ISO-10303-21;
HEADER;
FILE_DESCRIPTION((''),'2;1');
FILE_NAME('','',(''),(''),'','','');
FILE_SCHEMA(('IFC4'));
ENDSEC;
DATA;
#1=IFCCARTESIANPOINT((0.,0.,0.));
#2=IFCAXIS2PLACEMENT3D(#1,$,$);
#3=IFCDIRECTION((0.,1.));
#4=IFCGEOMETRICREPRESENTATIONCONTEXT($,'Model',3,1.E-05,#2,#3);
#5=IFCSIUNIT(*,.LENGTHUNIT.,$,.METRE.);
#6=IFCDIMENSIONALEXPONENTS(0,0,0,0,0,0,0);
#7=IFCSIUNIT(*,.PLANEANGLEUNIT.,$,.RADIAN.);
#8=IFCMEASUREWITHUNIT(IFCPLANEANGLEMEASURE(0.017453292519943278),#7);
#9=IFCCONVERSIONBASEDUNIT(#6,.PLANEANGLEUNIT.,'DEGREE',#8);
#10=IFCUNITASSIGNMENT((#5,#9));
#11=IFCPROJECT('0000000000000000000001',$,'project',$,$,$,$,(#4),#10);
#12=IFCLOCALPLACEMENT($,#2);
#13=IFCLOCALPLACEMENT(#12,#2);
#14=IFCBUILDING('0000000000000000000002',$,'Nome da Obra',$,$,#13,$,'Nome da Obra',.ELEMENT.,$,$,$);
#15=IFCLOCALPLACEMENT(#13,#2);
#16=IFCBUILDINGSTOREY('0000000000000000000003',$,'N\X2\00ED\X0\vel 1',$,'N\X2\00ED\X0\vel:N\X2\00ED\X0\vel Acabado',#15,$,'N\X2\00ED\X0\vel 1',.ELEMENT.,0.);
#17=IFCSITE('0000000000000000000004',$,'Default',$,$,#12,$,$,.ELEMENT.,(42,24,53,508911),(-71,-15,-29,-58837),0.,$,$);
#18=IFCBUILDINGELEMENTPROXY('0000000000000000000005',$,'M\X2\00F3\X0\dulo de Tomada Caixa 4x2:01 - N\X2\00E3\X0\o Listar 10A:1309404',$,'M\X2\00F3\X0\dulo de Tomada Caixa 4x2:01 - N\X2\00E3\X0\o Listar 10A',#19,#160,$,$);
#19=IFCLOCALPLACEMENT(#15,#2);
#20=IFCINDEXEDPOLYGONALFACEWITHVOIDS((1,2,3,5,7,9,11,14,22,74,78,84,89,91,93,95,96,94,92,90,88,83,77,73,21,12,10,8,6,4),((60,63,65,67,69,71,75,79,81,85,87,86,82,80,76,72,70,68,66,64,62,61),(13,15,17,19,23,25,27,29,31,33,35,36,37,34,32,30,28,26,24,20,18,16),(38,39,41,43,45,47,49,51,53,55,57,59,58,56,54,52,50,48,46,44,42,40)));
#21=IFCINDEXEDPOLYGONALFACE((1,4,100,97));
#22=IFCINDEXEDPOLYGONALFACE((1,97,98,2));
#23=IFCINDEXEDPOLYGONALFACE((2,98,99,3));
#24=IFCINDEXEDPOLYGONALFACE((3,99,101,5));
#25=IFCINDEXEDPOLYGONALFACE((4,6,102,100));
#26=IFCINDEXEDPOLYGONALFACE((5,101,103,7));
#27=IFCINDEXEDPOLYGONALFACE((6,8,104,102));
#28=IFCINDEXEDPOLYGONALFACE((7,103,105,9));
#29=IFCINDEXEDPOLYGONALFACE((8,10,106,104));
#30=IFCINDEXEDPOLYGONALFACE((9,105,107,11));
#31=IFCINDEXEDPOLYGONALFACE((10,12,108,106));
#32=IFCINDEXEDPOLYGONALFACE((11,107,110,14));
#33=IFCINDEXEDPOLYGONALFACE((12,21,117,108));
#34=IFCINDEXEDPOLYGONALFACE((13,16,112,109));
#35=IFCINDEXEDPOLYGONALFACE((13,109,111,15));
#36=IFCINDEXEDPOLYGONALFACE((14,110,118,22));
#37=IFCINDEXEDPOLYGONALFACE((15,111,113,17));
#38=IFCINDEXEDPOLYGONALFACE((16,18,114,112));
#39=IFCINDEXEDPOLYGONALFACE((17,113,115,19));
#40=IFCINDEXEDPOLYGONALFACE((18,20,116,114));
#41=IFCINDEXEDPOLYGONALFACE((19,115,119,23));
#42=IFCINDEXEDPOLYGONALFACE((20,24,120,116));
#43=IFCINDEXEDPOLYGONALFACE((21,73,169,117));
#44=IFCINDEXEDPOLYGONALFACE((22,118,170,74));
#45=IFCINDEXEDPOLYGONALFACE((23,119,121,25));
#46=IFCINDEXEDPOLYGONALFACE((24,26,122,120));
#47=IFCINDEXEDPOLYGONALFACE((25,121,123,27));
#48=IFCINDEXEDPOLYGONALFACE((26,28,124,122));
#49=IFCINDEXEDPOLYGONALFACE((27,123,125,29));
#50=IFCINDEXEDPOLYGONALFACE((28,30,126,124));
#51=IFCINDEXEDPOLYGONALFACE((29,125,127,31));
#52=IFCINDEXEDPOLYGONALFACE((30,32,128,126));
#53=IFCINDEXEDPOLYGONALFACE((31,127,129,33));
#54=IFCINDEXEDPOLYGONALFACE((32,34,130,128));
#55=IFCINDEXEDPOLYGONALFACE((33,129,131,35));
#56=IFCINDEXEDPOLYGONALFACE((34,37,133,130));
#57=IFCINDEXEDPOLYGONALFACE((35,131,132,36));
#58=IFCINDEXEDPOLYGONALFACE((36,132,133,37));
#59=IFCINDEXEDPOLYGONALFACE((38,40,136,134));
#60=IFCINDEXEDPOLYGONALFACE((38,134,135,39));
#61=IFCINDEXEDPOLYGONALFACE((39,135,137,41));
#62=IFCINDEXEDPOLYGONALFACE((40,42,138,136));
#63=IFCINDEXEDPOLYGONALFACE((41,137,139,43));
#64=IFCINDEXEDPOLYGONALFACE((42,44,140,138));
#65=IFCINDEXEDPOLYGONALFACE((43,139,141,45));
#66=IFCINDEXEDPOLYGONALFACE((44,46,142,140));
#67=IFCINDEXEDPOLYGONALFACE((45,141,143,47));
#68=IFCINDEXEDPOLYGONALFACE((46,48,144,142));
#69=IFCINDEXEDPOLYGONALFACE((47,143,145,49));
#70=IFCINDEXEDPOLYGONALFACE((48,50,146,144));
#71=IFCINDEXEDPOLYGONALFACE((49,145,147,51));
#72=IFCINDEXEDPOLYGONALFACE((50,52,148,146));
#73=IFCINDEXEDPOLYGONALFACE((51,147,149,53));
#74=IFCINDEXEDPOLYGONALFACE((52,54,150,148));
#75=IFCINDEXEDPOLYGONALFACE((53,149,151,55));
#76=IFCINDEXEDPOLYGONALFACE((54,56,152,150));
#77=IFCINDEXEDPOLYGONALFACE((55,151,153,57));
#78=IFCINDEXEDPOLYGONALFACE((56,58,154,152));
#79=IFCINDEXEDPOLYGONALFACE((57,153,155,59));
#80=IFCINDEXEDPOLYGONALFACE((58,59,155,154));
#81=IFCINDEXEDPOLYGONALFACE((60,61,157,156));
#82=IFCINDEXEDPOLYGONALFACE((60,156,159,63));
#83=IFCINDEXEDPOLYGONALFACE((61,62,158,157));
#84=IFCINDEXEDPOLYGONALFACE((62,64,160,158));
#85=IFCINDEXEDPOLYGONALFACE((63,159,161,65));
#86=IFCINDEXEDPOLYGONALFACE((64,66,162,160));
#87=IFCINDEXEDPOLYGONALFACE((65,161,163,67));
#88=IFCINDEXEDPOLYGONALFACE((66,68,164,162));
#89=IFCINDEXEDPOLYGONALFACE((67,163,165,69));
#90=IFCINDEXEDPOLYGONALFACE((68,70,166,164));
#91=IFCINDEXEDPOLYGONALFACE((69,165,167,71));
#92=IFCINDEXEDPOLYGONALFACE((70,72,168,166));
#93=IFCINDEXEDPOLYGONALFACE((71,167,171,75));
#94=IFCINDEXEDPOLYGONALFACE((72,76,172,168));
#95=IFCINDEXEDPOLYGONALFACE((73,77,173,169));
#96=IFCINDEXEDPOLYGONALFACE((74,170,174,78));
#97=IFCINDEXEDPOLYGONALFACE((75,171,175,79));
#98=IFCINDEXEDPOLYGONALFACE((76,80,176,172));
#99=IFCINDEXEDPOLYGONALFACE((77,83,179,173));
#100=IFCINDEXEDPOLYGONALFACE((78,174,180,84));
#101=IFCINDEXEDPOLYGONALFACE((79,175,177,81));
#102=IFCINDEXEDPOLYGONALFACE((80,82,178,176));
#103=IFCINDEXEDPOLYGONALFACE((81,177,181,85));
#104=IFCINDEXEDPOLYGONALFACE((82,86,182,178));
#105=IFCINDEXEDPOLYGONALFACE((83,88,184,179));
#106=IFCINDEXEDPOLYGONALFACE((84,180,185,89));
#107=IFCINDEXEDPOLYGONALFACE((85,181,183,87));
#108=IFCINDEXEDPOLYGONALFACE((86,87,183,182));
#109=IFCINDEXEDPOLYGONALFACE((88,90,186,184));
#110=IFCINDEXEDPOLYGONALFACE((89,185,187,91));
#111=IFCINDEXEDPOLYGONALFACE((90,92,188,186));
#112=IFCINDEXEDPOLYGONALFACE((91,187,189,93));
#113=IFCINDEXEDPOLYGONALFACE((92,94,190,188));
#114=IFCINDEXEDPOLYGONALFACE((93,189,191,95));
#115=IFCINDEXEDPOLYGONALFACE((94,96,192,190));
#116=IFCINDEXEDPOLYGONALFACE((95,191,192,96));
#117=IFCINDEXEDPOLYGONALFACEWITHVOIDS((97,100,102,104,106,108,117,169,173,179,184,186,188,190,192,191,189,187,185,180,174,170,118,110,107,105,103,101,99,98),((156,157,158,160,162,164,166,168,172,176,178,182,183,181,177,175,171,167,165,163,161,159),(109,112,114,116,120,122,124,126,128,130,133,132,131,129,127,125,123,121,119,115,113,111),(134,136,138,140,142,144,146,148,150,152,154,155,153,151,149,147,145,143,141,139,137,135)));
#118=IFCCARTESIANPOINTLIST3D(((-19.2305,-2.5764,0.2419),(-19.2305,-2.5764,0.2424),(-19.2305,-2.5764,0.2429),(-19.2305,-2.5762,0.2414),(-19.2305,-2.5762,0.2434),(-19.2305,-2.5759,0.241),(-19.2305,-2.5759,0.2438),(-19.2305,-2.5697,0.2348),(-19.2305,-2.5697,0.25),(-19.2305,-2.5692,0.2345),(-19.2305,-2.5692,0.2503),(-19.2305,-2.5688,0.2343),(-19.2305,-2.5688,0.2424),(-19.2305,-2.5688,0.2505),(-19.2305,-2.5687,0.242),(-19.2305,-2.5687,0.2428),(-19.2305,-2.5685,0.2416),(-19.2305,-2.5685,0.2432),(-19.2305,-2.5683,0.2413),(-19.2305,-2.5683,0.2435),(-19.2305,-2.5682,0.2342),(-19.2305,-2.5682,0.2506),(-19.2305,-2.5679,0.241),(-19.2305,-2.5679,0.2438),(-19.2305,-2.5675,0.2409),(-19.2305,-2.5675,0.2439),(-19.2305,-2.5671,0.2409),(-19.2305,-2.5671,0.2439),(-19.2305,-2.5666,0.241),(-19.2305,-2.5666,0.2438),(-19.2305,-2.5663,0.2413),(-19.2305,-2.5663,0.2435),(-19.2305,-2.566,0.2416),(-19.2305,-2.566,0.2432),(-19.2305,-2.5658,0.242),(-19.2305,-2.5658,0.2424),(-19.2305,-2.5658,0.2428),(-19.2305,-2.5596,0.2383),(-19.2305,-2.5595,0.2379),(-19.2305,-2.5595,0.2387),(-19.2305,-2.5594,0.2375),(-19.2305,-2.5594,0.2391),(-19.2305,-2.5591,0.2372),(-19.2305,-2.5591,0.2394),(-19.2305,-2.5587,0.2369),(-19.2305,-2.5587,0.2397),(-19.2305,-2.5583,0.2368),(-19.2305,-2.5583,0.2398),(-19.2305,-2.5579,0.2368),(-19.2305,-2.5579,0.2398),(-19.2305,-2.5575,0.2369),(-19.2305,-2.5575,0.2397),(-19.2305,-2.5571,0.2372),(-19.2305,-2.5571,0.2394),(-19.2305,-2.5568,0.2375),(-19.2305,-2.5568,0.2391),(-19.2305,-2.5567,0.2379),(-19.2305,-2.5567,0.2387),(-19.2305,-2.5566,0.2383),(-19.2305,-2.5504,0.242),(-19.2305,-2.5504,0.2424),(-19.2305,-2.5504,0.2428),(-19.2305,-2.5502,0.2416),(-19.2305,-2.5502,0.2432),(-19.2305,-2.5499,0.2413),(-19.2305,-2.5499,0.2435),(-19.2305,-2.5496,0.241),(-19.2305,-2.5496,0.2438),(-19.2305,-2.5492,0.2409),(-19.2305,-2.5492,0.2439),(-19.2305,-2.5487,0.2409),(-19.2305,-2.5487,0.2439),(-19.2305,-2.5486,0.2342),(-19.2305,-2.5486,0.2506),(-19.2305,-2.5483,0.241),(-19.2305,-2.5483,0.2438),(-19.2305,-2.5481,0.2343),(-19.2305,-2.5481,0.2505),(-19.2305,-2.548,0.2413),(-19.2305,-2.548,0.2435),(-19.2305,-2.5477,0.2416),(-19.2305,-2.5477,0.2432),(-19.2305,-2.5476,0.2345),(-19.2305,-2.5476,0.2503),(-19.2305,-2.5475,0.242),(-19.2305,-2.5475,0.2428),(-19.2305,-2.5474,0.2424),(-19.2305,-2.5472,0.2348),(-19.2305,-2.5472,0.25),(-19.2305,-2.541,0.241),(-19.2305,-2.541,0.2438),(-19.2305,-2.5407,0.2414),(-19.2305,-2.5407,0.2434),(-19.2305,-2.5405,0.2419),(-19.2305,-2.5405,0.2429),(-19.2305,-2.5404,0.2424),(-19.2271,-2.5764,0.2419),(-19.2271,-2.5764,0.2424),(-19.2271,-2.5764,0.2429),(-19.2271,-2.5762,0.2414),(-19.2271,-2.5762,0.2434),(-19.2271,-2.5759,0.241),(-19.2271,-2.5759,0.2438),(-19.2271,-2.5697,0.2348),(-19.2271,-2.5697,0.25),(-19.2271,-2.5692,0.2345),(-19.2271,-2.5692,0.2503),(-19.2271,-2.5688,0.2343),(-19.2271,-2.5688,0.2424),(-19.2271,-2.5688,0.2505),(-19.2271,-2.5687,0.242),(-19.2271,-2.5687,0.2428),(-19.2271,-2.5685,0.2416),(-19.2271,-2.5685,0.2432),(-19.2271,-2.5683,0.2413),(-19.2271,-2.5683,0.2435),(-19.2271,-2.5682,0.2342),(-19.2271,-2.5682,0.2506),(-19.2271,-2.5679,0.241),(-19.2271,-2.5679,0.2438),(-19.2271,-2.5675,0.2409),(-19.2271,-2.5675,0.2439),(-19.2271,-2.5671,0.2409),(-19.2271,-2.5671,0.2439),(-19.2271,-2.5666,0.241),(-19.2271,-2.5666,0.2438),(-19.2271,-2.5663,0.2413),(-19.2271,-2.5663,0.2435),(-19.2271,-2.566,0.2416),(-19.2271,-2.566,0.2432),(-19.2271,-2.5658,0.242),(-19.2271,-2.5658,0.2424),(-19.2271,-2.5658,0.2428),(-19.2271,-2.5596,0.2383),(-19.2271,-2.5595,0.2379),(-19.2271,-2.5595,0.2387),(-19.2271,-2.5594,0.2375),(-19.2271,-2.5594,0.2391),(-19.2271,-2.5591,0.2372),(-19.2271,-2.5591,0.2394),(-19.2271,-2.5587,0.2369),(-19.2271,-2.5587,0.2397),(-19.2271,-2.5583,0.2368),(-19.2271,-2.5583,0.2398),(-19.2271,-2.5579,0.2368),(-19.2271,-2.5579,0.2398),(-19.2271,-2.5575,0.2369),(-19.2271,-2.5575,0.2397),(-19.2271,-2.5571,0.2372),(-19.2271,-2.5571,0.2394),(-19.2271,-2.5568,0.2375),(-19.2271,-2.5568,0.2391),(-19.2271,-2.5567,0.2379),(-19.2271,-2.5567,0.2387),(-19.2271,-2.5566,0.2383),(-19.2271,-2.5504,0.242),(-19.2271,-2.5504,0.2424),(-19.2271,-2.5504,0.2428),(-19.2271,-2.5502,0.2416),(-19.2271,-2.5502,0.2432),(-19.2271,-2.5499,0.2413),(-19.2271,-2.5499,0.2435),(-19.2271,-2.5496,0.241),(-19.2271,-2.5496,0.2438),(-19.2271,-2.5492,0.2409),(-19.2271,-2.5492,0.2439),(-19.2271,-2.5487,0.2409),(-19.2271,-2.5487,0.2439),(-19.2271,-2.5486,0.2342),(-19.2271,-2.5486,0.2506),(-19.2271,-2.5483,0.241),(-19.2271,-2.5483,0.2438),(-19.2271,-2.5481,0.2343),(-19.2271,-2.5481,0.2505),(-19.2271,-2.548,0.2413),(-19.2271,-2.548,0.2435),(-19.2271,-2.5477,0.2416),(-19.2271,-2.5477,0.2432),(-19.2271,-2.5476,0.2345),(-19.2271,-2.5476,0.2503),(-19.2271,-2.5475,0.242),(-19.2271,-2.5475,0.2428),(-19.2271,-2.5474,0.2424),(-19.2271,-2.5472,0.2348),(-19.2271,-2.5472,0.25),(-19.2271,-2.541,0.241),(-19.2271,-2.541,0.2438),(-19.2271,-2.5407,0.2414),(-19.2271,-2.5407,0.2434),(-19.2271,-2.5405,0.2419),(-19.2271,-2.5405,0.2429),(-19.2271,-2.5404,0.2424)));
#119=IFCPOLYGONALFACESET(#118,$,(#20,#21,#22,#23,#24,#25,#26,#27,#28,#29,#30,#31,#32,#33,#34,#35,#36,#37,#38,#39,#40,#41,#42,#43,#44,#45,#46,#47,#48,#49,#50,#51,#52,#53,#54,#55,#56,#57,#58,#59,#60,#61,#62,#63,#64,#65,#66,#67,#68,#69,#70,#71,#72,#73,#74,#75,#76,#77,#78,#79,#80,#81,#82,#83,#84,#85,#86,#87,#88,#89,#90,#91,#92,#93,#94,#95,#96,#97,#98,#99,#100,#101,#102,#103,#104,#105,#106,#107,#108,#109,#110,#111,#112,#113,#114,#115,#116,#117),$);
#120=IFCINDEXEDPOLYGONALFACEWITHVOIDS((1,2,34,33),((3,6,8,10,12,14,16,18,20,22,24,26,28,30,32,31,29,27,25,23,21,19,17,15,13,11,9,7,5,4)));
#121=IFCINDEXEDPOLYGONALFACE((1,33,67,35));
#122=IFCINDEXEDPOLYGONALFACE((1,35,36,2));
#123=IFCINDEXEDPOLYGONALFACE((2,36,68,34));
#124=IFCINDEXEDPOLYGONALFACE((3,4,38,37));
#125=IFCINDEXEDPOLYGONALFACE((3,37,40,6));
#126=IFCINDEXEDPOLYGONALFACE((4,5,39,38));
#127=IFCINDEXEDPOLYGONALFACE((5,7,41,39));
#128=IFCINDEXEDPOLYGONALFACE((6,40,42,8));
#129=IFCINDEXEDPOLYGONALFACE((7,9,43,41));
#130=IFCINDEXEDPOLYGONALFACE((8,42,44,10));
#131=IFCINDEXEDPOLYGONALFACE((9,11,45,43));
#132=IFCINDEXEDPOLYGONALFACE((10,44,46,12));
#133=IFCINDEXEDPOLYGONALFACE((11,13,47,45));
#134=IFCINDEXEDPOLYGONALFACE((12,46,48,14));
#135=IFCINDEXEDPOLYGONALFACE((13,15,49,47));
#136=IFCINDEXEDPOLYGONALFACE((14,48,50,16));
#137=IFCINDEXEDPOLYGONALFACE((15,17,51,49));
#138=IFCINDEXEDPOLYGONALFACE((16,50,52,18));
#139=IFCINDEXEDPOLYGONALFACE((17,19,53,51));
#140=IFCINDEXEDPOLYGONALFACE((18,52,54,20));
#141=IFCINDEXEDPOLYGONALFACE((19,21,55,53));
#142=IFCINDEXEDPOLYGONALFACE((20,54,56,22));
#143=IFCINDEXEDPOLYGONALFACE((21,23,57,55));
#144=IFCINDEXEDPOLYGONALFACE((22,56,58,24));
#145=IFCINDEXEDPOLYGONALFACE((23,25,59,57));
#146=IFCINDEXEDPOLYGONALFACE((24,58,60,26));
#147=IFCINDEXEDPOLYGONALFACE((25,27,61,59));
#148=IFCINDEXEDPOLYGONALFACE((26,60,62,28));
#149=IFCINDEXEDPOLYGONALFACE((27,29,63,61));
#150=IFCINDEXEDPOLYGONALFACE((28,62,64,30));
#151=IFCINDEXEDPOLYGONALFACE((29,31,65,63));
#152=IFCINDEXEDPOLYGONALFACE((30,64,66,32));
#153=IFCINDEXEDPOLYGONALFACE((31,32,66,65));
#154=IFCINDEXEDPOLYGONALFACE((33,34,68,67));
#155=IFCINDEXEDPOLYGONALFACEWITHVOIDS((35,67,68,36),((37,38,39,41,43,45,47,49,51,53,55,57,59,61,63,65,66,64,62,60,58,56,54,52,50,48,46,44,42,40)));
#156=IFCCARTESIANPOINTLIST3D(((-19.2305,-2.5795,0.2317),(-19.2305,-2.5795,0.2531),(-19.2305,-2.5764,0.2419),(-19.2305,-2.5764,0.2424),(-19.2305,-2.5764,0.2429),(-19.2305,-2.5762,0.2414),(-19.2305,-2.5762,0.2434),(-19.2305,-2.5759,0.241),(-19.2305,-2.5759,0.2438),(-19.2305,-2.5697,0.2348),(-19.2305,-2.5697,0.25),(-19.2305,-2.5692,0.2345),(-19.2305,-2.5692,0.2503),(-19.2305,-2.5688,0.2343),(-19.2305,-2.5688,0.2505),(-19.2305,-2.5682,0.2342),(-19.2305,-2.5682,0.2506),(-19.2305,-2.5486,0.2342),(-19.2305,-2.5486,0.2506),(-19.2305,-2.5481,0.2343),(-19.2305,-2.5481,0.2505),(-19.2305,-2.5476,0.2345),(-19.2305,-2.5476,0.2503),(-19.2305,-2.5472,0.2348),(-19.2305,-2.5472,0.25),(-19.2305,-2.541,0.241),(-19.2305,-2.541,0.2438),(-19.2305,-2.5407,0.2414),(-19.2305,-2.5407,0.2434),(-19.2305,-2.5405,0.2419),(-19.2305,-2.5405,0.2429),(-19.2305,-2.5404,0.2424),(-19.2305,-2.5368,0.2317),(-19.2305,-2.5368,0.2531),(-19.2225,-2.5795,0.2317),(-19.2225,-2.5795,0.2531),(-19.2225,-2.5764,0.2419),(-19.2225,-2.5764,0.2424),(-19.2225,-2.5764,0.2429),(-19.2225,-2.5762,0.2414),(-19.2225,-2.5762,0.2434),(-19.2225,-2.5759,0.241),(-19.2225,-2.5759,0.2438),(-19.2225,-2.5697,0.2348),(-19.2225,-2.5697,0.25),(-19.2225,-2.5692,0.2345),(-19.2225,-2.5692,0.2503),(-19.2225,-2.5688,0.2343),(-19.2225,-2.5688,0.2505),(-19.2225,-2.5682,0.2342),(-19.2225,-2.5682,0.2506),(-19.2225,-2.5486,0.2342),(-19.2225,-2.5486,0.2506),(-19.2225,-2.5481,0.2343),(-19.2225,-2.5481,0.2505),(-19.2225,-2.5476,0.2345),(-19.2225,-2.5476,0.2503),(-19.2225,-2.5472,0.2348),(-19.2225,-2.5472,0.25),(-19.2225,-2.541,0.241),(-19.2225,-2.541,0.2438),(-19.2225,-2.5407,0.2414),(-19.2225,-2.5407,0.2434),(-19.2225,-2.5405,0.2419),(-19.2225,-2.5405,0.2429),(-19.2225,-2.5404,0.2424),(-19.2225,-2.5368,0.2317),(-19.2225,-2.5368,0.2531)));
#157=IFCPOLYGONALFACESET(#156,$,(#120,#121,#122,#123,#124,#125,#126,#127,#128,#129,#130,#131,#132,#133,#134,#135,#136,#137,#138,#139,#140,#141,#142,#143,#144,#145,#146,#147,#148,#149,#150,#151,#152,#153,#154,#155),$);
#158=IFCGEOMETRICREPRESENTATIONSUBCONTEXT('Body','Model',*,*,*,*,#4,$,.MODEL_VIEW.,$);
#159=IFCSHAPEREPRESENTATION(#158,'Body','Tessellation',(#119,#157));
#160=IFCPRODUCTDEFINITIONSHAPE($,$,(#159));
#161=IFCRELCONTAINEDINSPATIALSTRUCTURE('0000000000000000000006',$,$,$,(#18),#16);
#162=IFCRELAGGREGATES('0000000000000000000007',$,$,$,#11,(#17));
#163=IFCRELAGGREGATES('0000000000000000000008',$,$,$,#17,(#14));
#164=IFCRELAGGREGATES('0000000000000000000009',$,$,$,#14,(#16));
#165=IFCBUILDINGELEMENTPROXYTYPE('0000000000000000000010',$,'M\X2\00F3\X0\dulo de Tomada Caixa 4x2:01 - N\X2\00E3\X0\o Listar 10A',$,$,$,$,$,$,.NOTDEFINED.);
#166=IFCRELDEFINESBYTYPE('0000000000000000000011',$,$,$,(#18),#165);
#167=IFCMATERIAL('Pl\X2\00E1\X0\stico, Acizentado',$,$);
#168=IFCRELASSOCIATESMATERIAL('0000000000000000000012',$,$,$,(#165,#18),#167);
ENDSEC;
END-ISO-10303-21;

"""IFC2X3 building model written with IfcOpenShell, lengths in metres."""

from ifc_helpers import new_model, entity, si_unit, converted_unit, direction, frame, frame_2d, origin, place, context, subcontext, project, spatial, polyline, circle_curve, parameter, trimmed, segment, composite_curve, outline, extrude, source, transform, mapped, material, type_object, type_shapes, element, save


model = new_model("IFC2X3")

# Units and contexts
model_context = context("Model", 3, precision=1e-05, world=origin(), true_north=direction((0.0, 1.0)))
body_context = subcontext(model_context, "Body", "Model", "MODEL_VIEW")
ifc_project = project(units=[si_unit("LENGTHUNIT", "METRE"), converted_unit("PLANEANGLEUNIT", "DEGREE", entity("IfcPlaneAngleMeasure", 0.017453292519943278), si_unit("PLANEANGLEUNIT", "RADIAN"), dimensions=[0, 0, 0, 0, 0, 0, 0])], contexts=[model_context])

# Site, building, storey
site_placement = place(None, origin())
site = spatial("IfcSite", under=ifc_project, at=site_placement, Name="Default", CompositionType="ELEMENT", RefLatitude=(42, 24, 53, 508911), RefLongitude=(-71, -15, -29, -58837), RefElevation=0.0)
building_placement = place(site_placement, origin())
building = spatial("IfcBuilding", under=site, at=building_placement, Name="Nome da Obra", LongName="Nome da Obra", CompositionType="ELEMENT")
storey_placement = place(building_placement, origin())
storey = spatial("IfcBuildingStorey", under=building, at=storey_placement, Name="Nível 1", ObjectType="Nível:Nível Acabado", LongName="Nível 1", CompositionType="ELEMENT", Elevation=0.0)

# Building element proxy
ifc_material_1 = material(Name="Plástico, Acizentado")
building_element_proxy_type_1 = type_object("IfcBuildingElementProxyType", Name="Módulo de Tomada Caixa 4x2:01 - Não Listar 10A", PredefinedType="NOTDEFINED", material=ifc_material_1)
shared_shape_1 = source(origin(), body_context, "Body", "SweptSolid", [
    extrude(outline(composite_curve([segment(polyline([(-0.0098, -0.0082), (0.0098, -0.0082)]), True, "CONTINUOUS"), segment(trimmed(circle_curve(frame_2d((0.0098, -0.0062), x_axis=(1.0, 0.0)), 0.002), [parameter(270.0)], [parameter(315.0)], True, "PARAMETER"), True, "CONTINUOUS"), segment(polyline([(0.0112, -0.0076), (0.0174, -0.0014)]), True, "CONTINUOUS"), segment(trimmed(circle_curve(frame_2d((0.016, 0.0), x_axis=(1.0, 0.0)), 0.002), [parameter(315.0)], [parameter(45.0)], True, "PARAMETER"), True, "CONTINUOUS"), segment(polyline([(0.0174, 0.0014), (0.0112, 0.0076)]), True, "CONTINUOUS"), segment(trimmed(circle_curve(frame_2d((0.0098, 0.0062), x_axis=(1.0, 0.0)), 0.002), [parameter(45.0)], [parameter(90.0)], True, "PARAMETER"), True, "CONTINUOUS"), segment(polyline([(0.0098, 0.0082), (-0.0098, 0.0082)]), True, "CONTINUOUS"), segment(trimmed(circle_curve(frame_2d((-0.0098, 0.0062), x_axis=(1.0, 0.0)), 0.002), [parameter(90.0)], [parameter(135.0)], True, "PARAMETER"), True, "CONTINUOUS"), segment(polyline([(-0.0112, 0.0076), (-0.0174, 0.0014)]), True, "CONTINUOUS"), segment(trimmed(circle_curve(frame_2d((-0.016, 0.0), x_axis=(1.0, 0.0)), 0.002), [parameter(135.0)], [parameter(225.0)], True, "PARAMETER"), True, "CONTINUOUS"), segment(polyline([(-0.0174, -0.0014), (-0.0112, -0.0076)]), True, "CONTINUOUS"), segment(trimmed(circle_curve(frame_2d((-0.0098, -0.0062), x_axis=(1.0, 0.0)), 0.002), [parameter(225.0)], [parameter(270.0)], True, "PARAMETER"), True, "CONTINUOUS")], self_intersect=False), holes=[composite_curve([segment(trimmed(circle_curve(frame_2d((0.0089, 0.0), x_axis=(1.0, 0.0)), 0.0015), [parameter(0.0)], [parameter(180.0)], True, "PARAMETER"), False, "CONTINUOUS"), segment(trimmed(circle_curve(frame_2d((0.0089, 0.0), x_axis=(1.0, 0.0)), 0.0015), [parameter(180.0)], [parameter(0.0)], True, "PARAMETER"), False, "CONTINUOUS")], self_intersect=False), composite_curve([segment(trimmed(circle_curve(frame_2d((-0.0003, 0.0041), x_axis=(1.0, 0.0)), 0.0015), [parameter(0.0)], [parameter(180.0)], True, "PARAMETER"), False, "CONTINUOUS"), segment(trimmed(circle_curve(frame_2d((-0.0003, 0.0041), x_axis=(1.0, 0.0)), 0.0015), [parameter(180.0)], [parameter(0.0)], True, "PARAMETER"), False, "CONTINUOUS")], self_intersect=False), composite_curve([segment(trimmed(circle_curve(frame_2d((-0.0095, 0.0), x_axis=(1.0, 0.0)), 0.0015), [parameter(0.0)], [parameter(180.0)], True, "PARAMETER"), False, "CONTINUOUS"), segment(trimmed(circle_curve(frame_2d((-0.0095, 0.0), x_axis=(1.0, 0.0)), 0.0015), [parameter(180.0)], [parameter(0.0)], True, "PARAMETER"), False, "CONTINUOUS")], self_intersect=False)]), frame((0.0003, 0.0, 0.125), z_axis=(0.0, 1.0, 0.0), x_axis=(1.0, 0.0, 0.0)), (0.0, 0.0, 1.0), 0.0034),
    extrude(outline(polyline([(-0.0214, -0.0107), (0.0214, -0.0107), (0.0214, 0.0107), (-0.0214, 0.0107), (-0.0214, -0.0107)]), holes=[composite_curve([segment(polyline([(0.0101, -0.0082), (-0.0095, -0.0082)]), True, "CONTINUOUS"), segment(trimmed(circle_curve(frame_2d((-0.0095, -0.0062), x_axis=(1.0, 0.0)), 0.002), [parameter(225.0)], [parameter(270.0)], True, "PARAMETER"), False, "CONTINUOUS"), segment(polyline([(-0.0109, -0.0076), (-0.0171, -0.0014)]), True, "CONTINUOUS"), segment(trimmed(circle_curve(frame_2d((-0.0157, 0.0), x_axis=(1.0, 0.0)), 0.002), [parameter(135.0)], [parameter(225.0)], True, "PARAMETER"), False, "CONTINUOUS"), segment(polyline([(-0.0171, 0.0014), (-0.0109, 0.0076)]), True, "CONTINUOUS"), segment(trimmed(circle_curve(frame_2d((-0.0095, 0.0062), x_axis=(1.0, 0.0)), 0.002), [parameter(90.0)], [parameter(135.0)], True, "PARAMETER"), False, "CONTINUOUS"), segment(polyline([(-0.0095, 0.0082), (0.0101, 0.0082)]), True, "CONTINUOUS"), segment(trimmed(circle_curve(frame_2d((0.0101, 0.0062), x_axis=(1.0, 0.0)), 0.002), [parameter(45.0)], [parameter(90.0)], True, "PARAMETER"), False, "CONTINUOUS"), segment(polyline([(0.0115, 0.0076), (0.0177, 0.0014)]), True, "CONTINUOUS"), segment(trimmed(circle_curve(frame_2d((0.0163, 0.0), x_axis=(1.0, 0.0)), 0.002), [parameter(315.0)], [parameter(45.0)], True, "PARAMETER"), False, "CONTINUOUS"), segment(polyline([(0.0177, -0.0014), (0.0115, -0.0076)]), True, "CONTINUOUS"), segment(trimmed(circle_curve(frame_2d((0.0101, -0.0062), x_axis=(1.0, 0.0)), 0.002), [parameter(270.0)], [parameter(315.0)], True, "PARAMETER"), False, "CONTINUOUS")], self_intersect=False)]), frame((0.0, 0.0, 0.125), z_axis=(0.0, 1.0, 0.0), x_axis=(1.0, 0.0, 0.0)), (0.0, 0.0, 1.0), 0.008),
])
type_shapes(building_element_proxy_type_1, [shared_shape_1])
for number, where, z_axis, x_axis, name in (
    (1, (-19.2305, -2.5581, 0.1174), (0.0, 0.0, 1.0), (-0.000002, -1.0, 0.0), "Módulo de Tomada Caixa 4x2:01 - Não Listar 10A:1309404"),
):
    element("IfcBuildingElementProxy", number, at=place(storey_placement, frame(where, z_axis=z_axis, x_axis=x_axis)), inside=storey, type_object=building_element_proxy_type_1, material=ifc_material_1, Name=name, ObjectType="Módulo de Tomada Caixa 4x2:01 - Não Listar 10A", context=body_context, shape_type="MappedRepresentation", body=[
        mapped(shared_shape_1, transform((0.0, 0.0, 0.0), scale=1.0)),
    ])

save(model, "model.ifc")
